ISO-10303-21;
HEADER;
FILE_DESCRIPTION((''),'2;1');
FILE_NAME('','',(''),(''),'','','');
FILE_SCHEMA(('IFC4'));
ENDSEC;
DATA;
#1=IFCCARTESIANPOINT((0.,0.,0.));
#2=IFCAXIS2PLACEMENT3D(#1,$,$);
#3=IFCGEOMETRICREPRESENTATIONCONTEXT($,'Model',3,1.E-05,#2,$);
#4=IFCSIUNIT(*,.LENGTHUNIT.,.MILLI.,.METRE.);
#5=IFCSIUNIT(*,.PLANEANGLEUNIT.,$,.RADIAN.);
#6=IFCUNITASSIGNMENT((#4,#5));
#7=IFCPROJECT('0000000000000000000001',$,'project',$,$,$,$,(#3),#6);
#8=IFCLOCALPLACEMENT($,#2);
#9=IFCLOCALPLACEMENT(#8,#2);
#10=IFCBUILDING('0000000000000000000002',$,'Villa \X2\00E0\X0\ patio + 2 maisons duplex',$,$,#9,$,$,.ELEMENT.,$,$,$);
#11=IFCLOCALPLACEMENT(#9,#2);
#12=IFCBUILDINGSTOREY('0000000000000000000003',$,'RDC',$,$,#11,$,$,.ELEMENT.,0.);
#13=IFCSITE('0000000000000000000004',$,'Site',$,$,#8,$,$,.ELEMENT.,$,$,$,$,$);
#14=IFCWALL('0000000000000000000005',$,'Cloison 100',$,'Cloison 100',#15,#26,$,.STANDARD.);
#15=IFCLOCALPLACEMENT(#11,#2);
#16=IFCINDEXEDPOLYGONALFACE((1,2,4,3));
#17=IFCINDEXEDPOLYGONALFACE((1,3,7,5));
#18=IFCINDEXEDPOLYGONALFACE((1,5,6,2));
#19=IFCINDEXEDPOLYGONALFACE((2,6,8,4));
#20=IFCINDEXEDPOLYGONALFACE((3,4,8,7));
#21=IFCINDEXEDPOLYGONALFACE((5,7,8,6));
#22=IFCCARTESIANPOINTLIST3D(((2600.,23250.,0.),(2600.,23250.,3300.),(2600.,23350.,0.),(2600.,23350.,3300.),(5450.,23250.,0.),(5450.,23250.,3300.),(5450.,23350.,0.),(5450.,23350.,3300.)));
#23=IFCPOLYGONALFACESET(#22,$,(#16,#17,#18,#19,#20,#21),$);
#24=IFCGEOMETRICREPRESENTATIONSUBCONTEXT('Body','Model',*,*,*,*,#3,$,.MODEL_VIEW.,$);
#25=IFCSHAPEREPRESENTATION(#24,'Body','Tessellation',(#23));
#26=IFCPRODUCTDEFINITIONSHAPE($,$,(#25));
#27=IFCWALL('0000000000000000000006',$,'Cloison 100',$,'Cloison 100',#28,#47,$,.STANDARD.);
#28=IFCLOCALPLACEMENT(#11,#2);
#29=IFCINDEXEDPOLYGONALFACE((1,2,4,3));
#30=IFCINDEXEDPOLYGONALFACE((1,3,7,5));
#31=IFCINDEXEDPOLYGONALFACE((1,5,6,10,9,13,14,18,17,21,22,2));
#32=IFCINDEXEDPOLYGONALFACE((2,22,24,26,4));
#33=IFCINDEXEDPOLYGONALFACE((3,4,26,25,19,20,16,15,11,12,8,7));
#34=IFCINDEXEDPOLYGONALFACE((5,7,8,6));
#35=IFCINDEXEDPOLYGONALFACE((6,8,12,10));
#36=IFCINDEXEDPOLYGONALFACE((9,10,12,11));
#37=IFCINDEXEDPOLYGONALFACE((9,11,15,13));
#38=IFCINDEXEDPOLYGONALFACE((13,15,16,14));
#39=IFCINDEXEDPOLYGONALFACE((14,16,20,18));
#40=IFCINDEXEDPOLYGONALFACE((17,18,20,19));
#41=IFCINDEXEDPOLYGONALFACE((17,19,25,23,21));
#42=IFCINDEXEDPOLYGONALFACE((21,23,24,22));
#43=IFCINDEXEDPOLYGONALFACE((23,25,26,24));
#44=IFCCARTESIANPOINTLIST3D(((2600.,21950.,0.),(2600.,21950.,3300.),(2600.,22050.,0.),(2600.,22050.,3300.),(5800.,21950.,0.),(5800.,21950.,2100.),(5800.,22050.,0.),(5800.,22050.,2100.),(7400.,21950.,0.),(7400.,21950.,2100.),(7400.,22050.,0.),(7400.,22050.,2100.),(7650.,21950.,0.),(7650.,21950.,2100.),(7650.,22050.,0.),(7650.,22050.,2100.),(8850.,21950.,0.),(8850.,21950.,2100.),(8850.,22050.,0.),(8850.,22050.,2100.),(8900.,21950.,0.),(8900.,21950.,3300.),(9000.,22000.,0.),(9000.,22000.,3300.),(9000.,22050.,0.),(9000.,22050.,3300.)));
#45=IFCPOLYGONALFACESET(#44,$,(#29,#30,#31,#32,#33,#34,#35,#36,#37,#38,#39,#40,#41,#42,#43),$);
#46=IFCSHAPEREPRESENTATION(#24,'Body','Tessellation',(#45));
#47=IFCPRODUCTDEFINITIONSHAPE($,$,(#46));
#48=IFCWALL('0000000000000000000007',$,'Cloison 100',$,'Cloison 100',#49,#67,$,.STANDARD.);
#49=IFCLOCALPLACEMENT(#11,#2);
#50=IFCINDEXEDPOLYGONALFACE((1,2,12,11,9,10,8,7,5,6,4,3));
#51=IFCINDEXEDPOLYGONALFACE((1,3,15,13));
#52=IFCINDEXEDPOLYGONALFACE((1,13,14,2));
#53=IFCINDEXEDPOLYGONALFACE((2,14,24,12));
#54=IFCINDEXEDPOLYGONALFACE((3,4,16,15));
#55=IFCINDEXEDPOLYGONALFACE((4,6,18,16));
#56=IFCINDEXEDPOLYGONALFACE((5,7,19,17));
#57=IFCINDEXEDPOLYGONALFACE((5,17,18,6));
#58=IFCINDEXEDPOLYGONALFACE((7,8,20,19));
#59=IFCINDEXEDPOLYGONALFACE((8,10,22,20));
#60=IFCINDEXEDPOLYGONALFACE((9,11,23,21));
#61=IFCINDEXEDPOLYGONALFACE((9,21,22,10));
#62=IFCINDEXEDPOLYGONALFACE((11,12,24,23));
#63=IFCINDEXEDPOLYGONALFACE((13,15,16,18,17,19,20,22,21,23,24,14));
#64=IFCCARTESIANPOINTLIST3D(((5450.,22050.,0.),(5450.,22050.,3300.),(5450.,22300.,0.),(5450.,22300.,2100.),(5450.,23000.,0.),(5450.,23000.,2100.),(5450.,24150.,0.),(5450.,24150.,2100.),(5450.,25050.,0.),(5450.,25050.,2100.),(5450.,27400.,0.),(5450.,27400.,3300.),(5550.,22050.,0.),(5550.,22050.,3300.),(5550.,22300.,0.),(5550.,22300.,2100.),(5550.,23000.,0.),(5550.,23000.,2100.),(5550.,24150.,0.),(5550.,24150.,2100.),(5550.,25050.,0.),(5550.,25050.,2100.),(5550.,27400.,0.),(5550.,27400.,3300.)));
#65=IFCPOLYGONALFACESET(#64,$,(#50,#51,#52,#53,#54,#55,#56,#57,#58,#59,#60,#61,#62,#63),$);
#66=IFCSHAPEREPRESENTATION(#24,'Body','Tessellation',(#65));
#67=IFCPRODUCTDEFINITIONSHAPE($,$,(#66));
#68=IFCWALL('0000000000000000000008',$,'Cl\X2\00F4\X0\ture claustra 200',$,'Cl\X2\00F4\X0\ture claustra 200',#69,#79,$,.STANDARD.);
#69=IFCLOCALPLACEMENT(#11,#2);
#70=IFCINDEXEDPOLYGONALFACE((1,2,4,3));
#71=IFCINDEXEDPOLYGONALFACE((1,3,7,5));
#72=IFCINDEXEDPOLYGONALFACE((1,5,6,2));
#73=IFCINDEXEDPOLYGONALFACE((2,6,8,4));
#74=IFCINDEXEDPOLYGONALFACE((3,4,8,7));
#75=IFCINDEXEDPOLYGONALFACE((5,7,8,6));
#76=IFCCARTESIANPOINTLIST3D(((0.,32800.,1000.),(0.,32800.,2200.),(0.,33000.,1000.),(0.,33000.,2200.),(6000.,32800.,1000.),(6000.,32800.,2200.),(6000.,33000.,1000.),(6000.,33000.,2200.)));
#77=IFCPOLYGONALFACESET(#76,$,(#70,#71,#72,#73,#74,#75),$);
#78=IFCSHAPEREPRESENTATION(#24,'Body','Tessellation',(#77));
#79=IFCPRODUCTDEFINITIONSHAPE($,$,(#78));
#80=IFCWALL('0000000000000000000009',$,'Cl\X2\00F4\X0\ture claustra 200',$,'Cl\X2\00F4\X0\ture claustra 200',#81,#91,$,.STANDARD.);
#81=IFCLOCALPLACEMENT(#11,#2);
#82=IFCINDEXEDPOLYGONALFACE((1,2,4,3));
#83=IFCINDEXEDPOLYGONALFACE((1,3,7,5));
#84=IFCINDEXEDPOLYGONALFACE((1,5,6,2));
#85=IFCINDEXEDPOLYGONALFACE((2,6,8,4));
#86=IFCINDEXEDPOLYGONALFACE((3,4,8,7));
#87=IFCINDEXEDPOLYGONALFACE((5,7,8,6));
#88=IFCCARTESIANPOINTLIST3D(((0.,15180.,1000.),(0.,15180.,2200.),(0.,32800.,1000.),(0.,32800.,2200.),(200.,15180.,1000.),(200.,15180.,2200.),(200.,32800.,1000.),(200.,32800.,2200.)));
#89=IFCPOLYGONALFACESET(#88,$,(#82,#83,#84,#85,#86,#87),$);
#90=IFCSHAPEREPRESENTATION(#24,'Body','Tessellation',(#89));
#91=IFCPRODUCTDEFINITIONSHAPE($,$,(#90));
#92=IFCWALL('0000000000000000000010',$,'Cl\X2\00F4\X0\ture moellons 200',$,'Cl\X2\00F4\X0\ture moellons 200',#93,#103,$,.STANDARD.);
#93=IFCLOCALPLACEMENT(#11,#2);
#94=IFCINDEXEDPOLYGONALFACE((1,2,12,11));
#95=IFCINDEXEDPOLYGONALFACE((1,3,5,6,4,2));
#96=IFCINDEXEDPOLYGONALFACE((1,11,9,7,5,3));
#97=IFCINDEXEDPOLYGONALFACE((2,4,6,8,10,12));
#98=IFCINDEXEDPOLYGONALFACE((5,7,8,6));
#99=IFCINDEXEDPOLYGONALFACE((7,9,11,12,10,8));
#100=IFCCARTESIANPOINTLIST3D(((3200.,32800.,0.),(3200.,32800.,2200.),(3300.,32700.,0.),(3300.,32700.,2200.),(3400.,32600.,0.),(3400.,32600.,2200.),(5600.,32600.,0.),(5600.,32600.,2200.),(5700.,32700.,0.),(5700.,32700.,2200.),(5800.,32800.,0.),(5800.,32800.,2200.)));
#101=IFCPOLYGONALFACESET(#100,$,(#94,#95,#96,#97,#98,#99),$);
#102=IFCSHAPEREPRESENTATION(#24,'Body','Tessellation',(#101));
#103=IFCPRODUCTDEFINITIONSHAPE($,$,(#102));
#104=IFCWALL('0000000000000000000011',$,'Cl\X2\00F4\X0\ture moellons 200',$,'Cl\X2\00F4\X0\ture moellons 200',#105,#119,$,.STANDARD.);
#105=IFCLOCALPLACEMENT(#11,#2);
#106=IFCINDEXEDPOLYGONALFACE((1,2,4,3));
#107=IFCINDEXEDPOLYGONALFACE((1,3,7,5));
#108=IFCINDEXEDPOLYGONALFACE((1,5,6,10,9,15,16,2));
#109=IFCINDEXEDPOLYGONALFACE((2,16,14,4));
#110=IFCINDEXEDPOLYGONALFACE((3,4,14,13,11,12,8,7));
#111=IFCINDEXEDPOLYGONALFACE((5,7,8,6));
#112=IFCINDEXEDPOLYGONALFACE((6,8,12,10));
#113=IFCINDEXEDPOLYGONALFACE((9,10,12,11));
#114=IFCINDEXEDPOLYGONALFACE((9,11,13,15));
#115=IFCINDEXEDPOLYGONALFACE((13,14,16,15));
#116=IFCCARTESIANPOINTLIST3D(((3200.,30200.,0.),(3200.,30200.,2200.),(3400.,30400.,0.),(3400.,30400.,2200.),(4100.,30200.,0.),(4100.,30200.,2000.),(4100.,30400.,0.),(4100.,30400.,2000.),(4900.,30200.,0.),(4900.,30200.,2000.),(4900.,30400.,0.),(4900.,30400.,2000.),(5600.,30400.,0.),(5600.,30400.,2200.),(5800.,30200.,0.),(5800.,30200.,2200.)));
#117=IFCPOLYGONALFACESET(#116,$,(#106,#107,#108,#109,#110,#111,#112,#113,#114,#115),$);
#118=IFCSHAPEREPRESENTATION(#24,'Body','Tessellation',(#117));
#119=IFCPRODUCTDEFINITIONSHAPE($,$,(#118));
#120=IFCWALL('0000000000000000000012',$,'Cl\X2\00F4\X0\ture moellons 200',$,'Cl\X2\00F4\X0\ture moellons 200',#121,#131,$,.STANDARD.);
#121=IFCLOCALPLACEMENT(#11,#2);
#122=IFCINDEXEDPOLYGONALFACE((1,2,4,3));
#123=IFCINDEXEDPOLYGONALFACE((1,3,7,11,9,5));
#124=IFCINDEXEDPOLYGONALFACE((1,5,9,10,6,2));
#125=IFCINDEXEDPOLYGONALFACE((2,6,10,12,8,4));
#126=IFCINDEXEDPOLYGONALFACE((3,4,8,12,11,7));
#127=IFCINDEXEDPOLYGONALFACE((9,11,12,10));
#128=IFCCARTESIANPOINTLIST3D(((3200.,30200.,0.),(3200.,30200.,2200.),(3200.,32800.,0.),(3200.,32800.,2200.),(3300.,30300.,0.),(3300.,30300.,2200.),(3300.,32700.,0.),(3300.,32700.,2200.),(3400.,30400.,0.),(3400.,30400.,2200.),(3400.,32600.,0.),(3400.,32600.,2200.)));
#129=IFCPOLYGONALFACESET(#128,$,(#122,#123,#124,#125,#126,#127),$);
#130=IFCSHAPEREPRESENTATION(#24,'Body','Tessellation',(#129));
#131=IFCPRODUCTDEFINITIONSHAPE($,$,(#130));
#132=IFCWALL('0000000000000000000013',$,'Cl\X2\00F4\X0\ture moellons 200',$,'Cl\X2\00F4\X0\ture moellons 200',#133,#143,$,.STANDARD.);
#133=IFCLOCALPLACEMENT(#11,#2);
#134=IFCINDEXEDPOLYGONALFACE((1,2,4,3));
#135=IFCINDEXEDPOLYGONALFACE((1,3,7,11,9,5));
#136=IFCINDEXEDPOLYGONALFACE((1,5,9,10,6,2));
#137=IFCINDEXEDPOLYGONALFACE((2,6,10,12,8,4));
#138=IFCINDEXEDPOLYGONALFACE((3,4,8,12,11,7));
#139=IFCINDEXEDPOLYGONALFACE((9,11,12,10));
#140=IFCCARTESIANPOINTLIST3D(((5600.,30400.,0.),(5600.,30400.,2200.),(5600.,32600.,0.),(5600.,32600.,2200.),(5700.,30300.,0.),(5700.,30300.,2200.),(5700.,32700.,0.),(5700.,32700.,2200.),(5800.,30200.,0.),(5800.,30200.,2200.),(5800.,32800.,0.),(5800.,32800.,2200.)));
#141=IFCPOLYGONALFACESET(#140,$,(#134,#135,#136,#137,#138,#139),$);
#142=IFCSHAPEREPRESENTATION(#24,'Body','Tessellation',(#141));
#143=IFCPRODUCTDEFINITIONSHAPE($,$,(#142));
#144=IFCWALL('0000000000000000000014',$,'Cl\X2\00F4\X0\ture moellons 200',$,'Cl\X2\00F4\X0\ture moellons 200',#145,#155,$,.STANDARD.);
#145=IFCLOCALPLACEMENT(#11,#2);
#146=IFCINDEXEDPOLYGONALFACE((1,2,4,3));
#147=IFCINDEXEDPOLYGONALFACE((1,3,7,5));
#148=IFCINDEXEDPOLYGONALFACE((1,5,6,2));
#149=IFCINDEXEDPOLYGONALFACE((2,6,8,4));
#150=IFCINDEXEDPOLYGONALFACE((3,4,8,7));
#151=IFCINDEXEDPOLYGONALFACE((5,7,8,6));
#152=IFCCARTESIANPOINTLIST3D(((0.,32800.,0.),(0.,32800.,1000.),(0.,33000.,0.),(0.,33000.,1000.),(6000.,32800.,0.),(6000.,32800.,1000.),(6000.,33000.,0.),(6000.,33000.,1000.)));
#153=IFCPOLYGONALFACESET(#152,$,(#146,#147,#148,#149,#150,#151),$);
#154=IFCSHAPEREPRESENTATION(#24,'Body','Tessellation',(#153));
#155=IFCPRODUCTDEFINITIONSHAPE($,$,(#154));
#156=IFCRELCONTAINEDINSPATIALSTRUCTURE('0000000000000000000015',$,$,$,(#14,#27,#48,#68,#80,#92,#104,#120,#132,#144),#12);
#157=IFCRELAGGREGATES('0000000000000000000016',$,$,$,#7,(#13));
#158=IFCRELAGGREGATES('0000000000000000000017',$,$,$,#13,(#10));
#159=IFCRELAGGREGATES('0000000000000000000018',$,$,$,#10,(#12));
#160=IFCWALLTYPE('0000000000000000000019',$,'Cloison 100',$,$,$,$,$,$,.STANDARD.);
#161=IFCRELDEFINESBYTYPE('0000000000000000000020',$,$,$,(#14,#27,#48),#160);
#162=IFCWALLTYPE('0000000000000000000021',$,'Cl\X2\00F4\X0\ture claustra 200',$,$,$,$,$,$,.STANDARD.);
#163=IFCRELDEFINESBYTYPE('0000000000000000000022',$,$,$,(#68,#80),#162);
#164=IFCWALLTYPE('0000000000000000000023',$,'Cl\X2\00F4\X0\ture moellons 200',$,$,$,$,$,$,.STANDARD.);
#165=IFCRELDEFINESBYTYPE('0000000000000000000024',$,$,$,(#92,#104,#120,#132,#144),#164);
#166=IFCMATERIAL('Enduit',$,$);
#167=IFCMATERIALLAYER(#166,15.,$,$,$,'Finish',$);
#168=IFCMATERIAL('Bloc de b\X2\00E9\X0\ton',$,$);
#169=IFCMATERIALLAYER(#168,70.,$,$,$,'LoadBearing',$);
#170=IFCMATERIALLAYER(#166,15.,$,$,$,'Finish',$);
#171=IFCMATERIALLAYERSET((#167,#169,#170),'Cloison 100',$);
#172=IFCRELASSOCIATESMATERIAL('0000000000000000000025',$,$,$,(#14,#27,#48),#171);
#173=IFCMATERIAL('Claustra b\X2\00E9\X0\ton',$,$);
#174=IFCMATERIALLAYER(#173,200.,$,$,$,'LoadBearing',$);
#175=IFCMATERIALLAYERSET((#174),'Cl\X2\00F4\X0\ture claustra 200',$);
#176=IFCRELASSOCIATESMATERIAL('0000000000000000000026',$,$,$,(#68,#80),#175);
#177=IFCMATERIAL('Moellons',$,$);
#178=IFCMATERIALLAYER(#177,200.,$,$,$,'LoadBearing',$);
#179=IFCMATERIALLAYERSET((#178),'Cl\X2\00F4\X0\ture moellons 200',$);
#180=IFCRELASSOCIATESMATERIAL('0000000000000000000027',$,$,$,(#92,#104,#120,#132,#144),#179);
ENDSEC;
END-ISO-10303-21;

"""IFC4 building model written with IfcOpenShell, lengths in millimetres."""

from ifc_helpers import new_model, si_unit, frame, frame_2d, origin, place, context, subcontext, project, spatial, polyline, rectangle, outline, extrude, material, layer, layer_set, layer_usage, type_object, element, save


model = new_model("IFC4")

# Units and contexts
model_context = context("Model", 3, precision=1e-05, world=origin())
body_context = subcontext(model_context, "Body", "Model", "MODEL_VIEW")
ifc_project = project(units=[si_unit("LENGTHUNIT", "METRE", prefix="MILLI"), si_unit("PLANEANGLEUNIT", "RADIAN")], contexts=[model_context])

# Site, building, storey
site_placement = place(None, origin())
site = spatial("IfcSite", under=ifc_project, at=site_placement, Name="Site", CompositionType="ELEMENT")
building_placement = place(site_placement, origin())
building = spatial("IfcBuilding", under=site, at=building_placement, Name="Villa à patio + 2 maisons duplex", CompositionType="ELEMENT")
storey_placement = place(building_placement, origin())
storey = spatial("IfcBuildingStorey", under=building, at=storey_placement, Name="RDC", CompositionType="ELEMENT", Elevation=0.0)

# Wall
ifc_material_1 = material(Name="Enduit")
ifc_layer_1 = layer(ifc_material_1, 15.0, Category="Finish")
ifc_material_2 = material(Name="Bloc de béton")
ifc_layer_2 = layer(ifc_material_2, 70.0, Category="LoadBearing")
ifc_layer_3 = layer(ifc_material_1, 15.0, Category="Finish")
ifc_layer_set_1 = layer_set([ifc_layer_1, ifc_layer_2, ifc_layer_3], Name="Cloison 100")
ifc_layer_usage_1 = layer_usage(ifc_layer_set_1, "AXIS2", "NEGATIVE", 50.0)
wall_type_1 = type_object("IfcWallType", Name="Cloison 100", PredefinedType="STANDARD")
wall_1_placement = place(storey_placement, frame((2500.0, 23300.0, 0.0), z_axis=(0.0, 0.0, 1.0), x_axis=(1.0, 0.0, 0.0)))
element("IfcWall", 1, at=wall_1_placement, inside=storey, type_object=wall_type_1, material=ifc_layer_usage_1, Name="Cloison 100", ObjectType="Cloison 100", PredefinedType="STANDARD", context=body_context, shape_type="SweptSolid", body=[
    extrude(outline(polyline([(100.0, -50.0), (100.0, 50.0), (2950.0, 50.0), (2950.0, -50.0), (100.0, -50.0)])), origin(), (0.0, 0.0, 1.0), 3300.0),
])

# Walls, openings
wall_2_placement = place(storey_placement, frame((2500.0, 22000.0, 0.0), z_axis=(0.0, 0.0, 1.0), x_axis=(1.0, 0.0, 0.0)))
wall_2 = element("IfcWall", 2, at=wall_2_placement, inside=storey, type_object=wall_type_1, material=ifc_layer_usage_1, Name="Cloison 100", ObjectType="Cloison 100", PredefinedType="STANDARD", context=body_context, shape_type="SweptSolid", body=[
    extrude(outline(polyline([(100.0, -50.0), (100.0, 50.0), (6500.0, 50.0), (6500.0, 0.0), (6400.0, -50.0), (100.0, -50.0)])), origin(), (0.0, 0.0, 1.0), 3300.0),
])
opening_1_placement = place(wall_2_placement, frame((3300.0, 0.0, 0.0), z_axis=(0.0, 0.0, 1.0), x_axis=(1.0, 0.0, 0.0)))
element("IfcOpeningElement", 3, at=opening_1_placement, cuts=wall_2, PredefinedType="OPENING", context=body_context, shape_type="SweptSolid", body=[
    extrude(rectangle(XDim=1600.0, YDim=120.0, at=frame_2d((800.0, 0.0))), origin(), (0.0, 0.0, 1.0), 2100.0),
])
opening_2_placement = place(wall_2_placement, frame((5150.0, 0.0, 0.0), z_axis=(0.0, 0.0, 1.0), x_axis=(1.0, 0.0, 0.0)))
element("IfcOpeningElement", 4, at=opening_2_placement, cuts=wall_2, PredefinedType="OPENING", context=body_context, shape_type="SweptSolid", body=[
    extrude(rectangle(XDim=1200.0, YDim=120.0, at=frame_2d((600.0, 0.0))), origin(), (0.0, 0.0, 1.0), 2100.0),
])
wall_3_placement = place(storey_placement, frame((5500.0, 27500.0, 0.0), z_axis=(0.0, 0.0, 1.0), x_axis=(0.0, -1.0, 0.0)))
wall_3 = element("IfcWall", 5, at=wall_3_placement, inside=storey, type_object=wall_type_1, material=ifc_layer_usage_1, Name="Cloison 100", ObjectType="Cloison 100", PredefinedType="STANDARD", context=body_context, shape_type="SweptSolid", body=[
    extrude(outline(polyline([(100.0, -50.0), (100.0, 50.0), (5450.0, 50.0), (5450.0, -50.0), (100.0, -50.0)])), origin(), (0.0, 0.0, 1.0), 3300.0),
])
opening_3_placement = place(wall_3_placement, frame((2450.0, 0.0, 0.0), z_axis=(0.0, 0.0, 1.0), x_axis=(1.0, 0.0, 0.0)))
element("IfcOpeningElement", 6, at=opening_3_placement, cuts=wall_3, PredefinedType="OPENING", context=body_context, shape_type="SweptSolid", body=[
    extrude(rectangle(XDim=900.0, YDim=120.0, at=frame_2d((450.0, 0.0))), origin(), (0.0, 0.0, 1.0), 2100.0),
])
opening_4_placement = place(wall_3_placement, frame((4500.0, 0.0, 0.0), z_axis=(0.0, 0.0, 1.0), x_axis=(1.0, 0.0, 0.0)))
element("IfcOpeningElement", 7, at=opening_4_placement, cuts=wall_3, PredefinedType="OPENING", context=body_context, shape_type="SweptSolid", body=[
    extrude(rectangle(XDim=700.0, YDim=120.0, at=frame_2d((350.0, 0.0))), origin(), (0.0, 0.0, 1.0), 2100.0),
])

# Walls
ifc_material_3 = material(Name="Claustra béton")
ifc_layer_4 = layer(ifc_material_3, 200.0, Category="LoadBearing")
ifc_layer_set_2 = layer_set([ifc_layer_4], Name="Clôture claustra 200")
ifc_layer_usage_2 = layer_usage(ifc_layer_set_2, "AXIS2", "NEGATIVE", 100.0)
wall_type_2 = type_object("IfcWallType", Name="Clôture claustra 200", PredefinedType="STANDARD")
wall_4_placement = place(storey_placement, frame((0.0, 32900.0, 1000.0), z_axis=(0.0, 0.0, 1.0), x_axis=(1.0, 0.0, 0.0)))
element("IfcWall", 8, at=wall_4_placement, inside=storey, type_object=wall_type_2, material=ifc_layer_usage_2, Name="Clôture claustra 200", ObjectType="Clôture claustra 200", PredefinedType="STANDARD", context=body_context, shape_type="SweptSolid", body=[
    extrude(outline(polyline([(0.0, -100.0), (0.0, 100.0), (6000.0, 100.0), (6000.0, -100.0), (0.0, -100.0)])), origin(), (0.0, 0.0, 1.0), 1200.0),
])
wall_5_placement = place(storey_placement, frame((100.0, 32800.0, 1000.0), z_axis=(0.0, 0.0, 1.0), x_axis=(0.0, -1.0, 0.0)))
element("IfcWall", 9, at=wall_5_placement, inside=storey, type_object=wall_type_2, material=ifc_layer_usage_2, Name="Clôture claustra 200", ObjectType="Clôture claustra 200", PredefinedType="STANDARD", context=body_context, shape_type="SweptSolid", body=[
    extrude(outline(polyline([(0.0, -100.0), (0.0, 100.0), (17620.0, 100.0), (17620.0, -100.0), (0.0, -100.0)])), origin(), (0.0, 0.0, 1.0), 1200.0),
])
ifc_material_4 = material(Name="Moellons")
ifc_layer_5 = layer(ifc_material_4, 200.0, Category="LoadBearing")
ifc_layer_set_3 = layer_set([ifc_layer_5], Name="Clôture moellons 200")
ifc_layer_usage_3 = layer_usage(ifc_layer_set_3, "AXIS2", "NEGATIVE", 100.0)
wall_type_3 = type_object("IfcWallType", Name="Clôture moellons 200", PredefinedType="STANDARD")
wall_6_placement = place(storey_placement, frame((3300.0, 32700.0, 0.0), z_axis=(0.0, 0.0, 1.0), x_axis=(1.0, 0.0, 0.0)))
element("IfcWall", 10, at=wall_6_placement, inside=storey, type_object=wall_type_3, material=ifc_layer_usage_3, Name="Clôture moellons 200", ObjectType="Clôture moellons 200", PredefinedType="STANDARD", context=body_context, shape_type="SweptSolid", body=[
    extrude(outline(polyline([(100.0, -100.0), (0.0, 0.0), (-100.0, 100.0), (2500.0, 100.0), (2400.0, 0.0), (2300.0, -100.0), (100.0, -100.0)])), origin(), (0.0, 0.0, 1.0), 2200.0),
])

# Wall, opening
wall_7_placement = place(storey_placement, frame((3300.0, 30300.0, 0.0), z_axis=(0.0, 0.0, 1.0), x_axis=(1.0, 0.0, 0.0)))
wall_7 = element("IfcWall", 11, at=wall_7_placement, inside=storey, type_object=wall_type_3, material=ifc_layer_usage_3, Name="Clôture moellons 200", ObjectType="Clôture moellons 200", PredefinedType="STANDARD", context=body_context, shape_type="SweptSolid", body=[
    extrude(outline(polyline([(-100.0, -100.0), (0.0, 0.0), (100.0, 100.0), (2300.0, 100.0), (2400.0, 0.0), (2500.0, -100.0), (-100.0, -100.0)])), origin(), (0.0, 0.0, 1.0), 2200.0),
])
opening_5_placement = place(wall_7_placement, frame((800.0, 0.0, 0.0), z_axis=(0.0, 0.0, 1.0), x_axis=(1.0, 0.0, 0.0)))
element("IfcOpeningElement", 12, at=opening_5_placement, cuts=wall_7, PredefinedType="OPENING", context=body_context, shape_type="SweptSolid", body=[
    extrude(rectangle(XDim=800.0, YDim=220.0, at=frame_2d((400.0, 0.0))), origin(), (0.0, 0.0, 1.0), 2000.0),
])

# Walls
wall_8_placement = place(storey_placement, frame((3300.0, 32700.0, 0.0), z_axis=(0.0, 0.0, 1.0), x_axis=(0.0, -1.0, 0.0)))
element("IfcWall", 13, at=wall_8_placement, inside=storey, type_object=wall_type_3, material=ifc_layer_usage_3, Name="Clôture moellons 200", ObjectType="Clôture moellons 200", PredefinedType="STANDARD", context=body_context, shape_type="SweptSolid", body=[
    extrude(outline(polyline([(-100.0, -100.0), (0.0, 0.0), (100.0, 100.0), (2300.0, 100.0), (2400.0, 0.0), (2500.0, -100.0), (-100.0, -100.0)])), origin(), (0.0, 0.0, 1.0), 2200.0),
])
wall_9_placement = place(storey_placement, frame((5700.0, 32700.0, 0.0), z_axis=(0.0, 0.0, 1.0), x_axis=(0.0, -1.0, 0.0)))
element("IfcWall", 14, at=wall_9_placement, inside=storey, type_object=wall_type_3, material=ifc_layer_usage_3, Name="Clôture moellons 200", ObjectType="Clôture moellons 200", PredefinedType="STANDARD", context=body_context, shape_type="SweptSolid", body=[
    extrude(outline(polyline([(100.0, -100.0), (0.0, 0.0), (-100.0, 100.0), (2500.0, 100.0), (2400.0, 0.0), (2300.0, -100.0), (100.0, -100.0)])), origin(), (0.0, 0.0, 1.0), 2200.0),
])
wall_10_placement = place(storey_placement, frame((0.0, 32900.0, 0.0), z_axis=(0.0, 0.0, 1.0), x_axis=(1.0, 0.0, 0.0)))
element("IfcWall", 15, at=wall_10_placement, inside=storey, type_object=wall_type_3, material=ifc_layer_usage_3, Name="Clôture moellons 200", ObjectType="Clôture moellons 200", PredefinedType="STANDARD", context=body_context, shape_type="SweptSolid", body=[
    extrude(outline(polyline([(0.0, -100.0), (0.0, 100.0), (6000.0, 100.0), (6000.0, -100.0), (0.0, -100.0)])), origin(), (0.0, 0.0, 1.0), 1000.0),
])

save(model, "model.ifc")
